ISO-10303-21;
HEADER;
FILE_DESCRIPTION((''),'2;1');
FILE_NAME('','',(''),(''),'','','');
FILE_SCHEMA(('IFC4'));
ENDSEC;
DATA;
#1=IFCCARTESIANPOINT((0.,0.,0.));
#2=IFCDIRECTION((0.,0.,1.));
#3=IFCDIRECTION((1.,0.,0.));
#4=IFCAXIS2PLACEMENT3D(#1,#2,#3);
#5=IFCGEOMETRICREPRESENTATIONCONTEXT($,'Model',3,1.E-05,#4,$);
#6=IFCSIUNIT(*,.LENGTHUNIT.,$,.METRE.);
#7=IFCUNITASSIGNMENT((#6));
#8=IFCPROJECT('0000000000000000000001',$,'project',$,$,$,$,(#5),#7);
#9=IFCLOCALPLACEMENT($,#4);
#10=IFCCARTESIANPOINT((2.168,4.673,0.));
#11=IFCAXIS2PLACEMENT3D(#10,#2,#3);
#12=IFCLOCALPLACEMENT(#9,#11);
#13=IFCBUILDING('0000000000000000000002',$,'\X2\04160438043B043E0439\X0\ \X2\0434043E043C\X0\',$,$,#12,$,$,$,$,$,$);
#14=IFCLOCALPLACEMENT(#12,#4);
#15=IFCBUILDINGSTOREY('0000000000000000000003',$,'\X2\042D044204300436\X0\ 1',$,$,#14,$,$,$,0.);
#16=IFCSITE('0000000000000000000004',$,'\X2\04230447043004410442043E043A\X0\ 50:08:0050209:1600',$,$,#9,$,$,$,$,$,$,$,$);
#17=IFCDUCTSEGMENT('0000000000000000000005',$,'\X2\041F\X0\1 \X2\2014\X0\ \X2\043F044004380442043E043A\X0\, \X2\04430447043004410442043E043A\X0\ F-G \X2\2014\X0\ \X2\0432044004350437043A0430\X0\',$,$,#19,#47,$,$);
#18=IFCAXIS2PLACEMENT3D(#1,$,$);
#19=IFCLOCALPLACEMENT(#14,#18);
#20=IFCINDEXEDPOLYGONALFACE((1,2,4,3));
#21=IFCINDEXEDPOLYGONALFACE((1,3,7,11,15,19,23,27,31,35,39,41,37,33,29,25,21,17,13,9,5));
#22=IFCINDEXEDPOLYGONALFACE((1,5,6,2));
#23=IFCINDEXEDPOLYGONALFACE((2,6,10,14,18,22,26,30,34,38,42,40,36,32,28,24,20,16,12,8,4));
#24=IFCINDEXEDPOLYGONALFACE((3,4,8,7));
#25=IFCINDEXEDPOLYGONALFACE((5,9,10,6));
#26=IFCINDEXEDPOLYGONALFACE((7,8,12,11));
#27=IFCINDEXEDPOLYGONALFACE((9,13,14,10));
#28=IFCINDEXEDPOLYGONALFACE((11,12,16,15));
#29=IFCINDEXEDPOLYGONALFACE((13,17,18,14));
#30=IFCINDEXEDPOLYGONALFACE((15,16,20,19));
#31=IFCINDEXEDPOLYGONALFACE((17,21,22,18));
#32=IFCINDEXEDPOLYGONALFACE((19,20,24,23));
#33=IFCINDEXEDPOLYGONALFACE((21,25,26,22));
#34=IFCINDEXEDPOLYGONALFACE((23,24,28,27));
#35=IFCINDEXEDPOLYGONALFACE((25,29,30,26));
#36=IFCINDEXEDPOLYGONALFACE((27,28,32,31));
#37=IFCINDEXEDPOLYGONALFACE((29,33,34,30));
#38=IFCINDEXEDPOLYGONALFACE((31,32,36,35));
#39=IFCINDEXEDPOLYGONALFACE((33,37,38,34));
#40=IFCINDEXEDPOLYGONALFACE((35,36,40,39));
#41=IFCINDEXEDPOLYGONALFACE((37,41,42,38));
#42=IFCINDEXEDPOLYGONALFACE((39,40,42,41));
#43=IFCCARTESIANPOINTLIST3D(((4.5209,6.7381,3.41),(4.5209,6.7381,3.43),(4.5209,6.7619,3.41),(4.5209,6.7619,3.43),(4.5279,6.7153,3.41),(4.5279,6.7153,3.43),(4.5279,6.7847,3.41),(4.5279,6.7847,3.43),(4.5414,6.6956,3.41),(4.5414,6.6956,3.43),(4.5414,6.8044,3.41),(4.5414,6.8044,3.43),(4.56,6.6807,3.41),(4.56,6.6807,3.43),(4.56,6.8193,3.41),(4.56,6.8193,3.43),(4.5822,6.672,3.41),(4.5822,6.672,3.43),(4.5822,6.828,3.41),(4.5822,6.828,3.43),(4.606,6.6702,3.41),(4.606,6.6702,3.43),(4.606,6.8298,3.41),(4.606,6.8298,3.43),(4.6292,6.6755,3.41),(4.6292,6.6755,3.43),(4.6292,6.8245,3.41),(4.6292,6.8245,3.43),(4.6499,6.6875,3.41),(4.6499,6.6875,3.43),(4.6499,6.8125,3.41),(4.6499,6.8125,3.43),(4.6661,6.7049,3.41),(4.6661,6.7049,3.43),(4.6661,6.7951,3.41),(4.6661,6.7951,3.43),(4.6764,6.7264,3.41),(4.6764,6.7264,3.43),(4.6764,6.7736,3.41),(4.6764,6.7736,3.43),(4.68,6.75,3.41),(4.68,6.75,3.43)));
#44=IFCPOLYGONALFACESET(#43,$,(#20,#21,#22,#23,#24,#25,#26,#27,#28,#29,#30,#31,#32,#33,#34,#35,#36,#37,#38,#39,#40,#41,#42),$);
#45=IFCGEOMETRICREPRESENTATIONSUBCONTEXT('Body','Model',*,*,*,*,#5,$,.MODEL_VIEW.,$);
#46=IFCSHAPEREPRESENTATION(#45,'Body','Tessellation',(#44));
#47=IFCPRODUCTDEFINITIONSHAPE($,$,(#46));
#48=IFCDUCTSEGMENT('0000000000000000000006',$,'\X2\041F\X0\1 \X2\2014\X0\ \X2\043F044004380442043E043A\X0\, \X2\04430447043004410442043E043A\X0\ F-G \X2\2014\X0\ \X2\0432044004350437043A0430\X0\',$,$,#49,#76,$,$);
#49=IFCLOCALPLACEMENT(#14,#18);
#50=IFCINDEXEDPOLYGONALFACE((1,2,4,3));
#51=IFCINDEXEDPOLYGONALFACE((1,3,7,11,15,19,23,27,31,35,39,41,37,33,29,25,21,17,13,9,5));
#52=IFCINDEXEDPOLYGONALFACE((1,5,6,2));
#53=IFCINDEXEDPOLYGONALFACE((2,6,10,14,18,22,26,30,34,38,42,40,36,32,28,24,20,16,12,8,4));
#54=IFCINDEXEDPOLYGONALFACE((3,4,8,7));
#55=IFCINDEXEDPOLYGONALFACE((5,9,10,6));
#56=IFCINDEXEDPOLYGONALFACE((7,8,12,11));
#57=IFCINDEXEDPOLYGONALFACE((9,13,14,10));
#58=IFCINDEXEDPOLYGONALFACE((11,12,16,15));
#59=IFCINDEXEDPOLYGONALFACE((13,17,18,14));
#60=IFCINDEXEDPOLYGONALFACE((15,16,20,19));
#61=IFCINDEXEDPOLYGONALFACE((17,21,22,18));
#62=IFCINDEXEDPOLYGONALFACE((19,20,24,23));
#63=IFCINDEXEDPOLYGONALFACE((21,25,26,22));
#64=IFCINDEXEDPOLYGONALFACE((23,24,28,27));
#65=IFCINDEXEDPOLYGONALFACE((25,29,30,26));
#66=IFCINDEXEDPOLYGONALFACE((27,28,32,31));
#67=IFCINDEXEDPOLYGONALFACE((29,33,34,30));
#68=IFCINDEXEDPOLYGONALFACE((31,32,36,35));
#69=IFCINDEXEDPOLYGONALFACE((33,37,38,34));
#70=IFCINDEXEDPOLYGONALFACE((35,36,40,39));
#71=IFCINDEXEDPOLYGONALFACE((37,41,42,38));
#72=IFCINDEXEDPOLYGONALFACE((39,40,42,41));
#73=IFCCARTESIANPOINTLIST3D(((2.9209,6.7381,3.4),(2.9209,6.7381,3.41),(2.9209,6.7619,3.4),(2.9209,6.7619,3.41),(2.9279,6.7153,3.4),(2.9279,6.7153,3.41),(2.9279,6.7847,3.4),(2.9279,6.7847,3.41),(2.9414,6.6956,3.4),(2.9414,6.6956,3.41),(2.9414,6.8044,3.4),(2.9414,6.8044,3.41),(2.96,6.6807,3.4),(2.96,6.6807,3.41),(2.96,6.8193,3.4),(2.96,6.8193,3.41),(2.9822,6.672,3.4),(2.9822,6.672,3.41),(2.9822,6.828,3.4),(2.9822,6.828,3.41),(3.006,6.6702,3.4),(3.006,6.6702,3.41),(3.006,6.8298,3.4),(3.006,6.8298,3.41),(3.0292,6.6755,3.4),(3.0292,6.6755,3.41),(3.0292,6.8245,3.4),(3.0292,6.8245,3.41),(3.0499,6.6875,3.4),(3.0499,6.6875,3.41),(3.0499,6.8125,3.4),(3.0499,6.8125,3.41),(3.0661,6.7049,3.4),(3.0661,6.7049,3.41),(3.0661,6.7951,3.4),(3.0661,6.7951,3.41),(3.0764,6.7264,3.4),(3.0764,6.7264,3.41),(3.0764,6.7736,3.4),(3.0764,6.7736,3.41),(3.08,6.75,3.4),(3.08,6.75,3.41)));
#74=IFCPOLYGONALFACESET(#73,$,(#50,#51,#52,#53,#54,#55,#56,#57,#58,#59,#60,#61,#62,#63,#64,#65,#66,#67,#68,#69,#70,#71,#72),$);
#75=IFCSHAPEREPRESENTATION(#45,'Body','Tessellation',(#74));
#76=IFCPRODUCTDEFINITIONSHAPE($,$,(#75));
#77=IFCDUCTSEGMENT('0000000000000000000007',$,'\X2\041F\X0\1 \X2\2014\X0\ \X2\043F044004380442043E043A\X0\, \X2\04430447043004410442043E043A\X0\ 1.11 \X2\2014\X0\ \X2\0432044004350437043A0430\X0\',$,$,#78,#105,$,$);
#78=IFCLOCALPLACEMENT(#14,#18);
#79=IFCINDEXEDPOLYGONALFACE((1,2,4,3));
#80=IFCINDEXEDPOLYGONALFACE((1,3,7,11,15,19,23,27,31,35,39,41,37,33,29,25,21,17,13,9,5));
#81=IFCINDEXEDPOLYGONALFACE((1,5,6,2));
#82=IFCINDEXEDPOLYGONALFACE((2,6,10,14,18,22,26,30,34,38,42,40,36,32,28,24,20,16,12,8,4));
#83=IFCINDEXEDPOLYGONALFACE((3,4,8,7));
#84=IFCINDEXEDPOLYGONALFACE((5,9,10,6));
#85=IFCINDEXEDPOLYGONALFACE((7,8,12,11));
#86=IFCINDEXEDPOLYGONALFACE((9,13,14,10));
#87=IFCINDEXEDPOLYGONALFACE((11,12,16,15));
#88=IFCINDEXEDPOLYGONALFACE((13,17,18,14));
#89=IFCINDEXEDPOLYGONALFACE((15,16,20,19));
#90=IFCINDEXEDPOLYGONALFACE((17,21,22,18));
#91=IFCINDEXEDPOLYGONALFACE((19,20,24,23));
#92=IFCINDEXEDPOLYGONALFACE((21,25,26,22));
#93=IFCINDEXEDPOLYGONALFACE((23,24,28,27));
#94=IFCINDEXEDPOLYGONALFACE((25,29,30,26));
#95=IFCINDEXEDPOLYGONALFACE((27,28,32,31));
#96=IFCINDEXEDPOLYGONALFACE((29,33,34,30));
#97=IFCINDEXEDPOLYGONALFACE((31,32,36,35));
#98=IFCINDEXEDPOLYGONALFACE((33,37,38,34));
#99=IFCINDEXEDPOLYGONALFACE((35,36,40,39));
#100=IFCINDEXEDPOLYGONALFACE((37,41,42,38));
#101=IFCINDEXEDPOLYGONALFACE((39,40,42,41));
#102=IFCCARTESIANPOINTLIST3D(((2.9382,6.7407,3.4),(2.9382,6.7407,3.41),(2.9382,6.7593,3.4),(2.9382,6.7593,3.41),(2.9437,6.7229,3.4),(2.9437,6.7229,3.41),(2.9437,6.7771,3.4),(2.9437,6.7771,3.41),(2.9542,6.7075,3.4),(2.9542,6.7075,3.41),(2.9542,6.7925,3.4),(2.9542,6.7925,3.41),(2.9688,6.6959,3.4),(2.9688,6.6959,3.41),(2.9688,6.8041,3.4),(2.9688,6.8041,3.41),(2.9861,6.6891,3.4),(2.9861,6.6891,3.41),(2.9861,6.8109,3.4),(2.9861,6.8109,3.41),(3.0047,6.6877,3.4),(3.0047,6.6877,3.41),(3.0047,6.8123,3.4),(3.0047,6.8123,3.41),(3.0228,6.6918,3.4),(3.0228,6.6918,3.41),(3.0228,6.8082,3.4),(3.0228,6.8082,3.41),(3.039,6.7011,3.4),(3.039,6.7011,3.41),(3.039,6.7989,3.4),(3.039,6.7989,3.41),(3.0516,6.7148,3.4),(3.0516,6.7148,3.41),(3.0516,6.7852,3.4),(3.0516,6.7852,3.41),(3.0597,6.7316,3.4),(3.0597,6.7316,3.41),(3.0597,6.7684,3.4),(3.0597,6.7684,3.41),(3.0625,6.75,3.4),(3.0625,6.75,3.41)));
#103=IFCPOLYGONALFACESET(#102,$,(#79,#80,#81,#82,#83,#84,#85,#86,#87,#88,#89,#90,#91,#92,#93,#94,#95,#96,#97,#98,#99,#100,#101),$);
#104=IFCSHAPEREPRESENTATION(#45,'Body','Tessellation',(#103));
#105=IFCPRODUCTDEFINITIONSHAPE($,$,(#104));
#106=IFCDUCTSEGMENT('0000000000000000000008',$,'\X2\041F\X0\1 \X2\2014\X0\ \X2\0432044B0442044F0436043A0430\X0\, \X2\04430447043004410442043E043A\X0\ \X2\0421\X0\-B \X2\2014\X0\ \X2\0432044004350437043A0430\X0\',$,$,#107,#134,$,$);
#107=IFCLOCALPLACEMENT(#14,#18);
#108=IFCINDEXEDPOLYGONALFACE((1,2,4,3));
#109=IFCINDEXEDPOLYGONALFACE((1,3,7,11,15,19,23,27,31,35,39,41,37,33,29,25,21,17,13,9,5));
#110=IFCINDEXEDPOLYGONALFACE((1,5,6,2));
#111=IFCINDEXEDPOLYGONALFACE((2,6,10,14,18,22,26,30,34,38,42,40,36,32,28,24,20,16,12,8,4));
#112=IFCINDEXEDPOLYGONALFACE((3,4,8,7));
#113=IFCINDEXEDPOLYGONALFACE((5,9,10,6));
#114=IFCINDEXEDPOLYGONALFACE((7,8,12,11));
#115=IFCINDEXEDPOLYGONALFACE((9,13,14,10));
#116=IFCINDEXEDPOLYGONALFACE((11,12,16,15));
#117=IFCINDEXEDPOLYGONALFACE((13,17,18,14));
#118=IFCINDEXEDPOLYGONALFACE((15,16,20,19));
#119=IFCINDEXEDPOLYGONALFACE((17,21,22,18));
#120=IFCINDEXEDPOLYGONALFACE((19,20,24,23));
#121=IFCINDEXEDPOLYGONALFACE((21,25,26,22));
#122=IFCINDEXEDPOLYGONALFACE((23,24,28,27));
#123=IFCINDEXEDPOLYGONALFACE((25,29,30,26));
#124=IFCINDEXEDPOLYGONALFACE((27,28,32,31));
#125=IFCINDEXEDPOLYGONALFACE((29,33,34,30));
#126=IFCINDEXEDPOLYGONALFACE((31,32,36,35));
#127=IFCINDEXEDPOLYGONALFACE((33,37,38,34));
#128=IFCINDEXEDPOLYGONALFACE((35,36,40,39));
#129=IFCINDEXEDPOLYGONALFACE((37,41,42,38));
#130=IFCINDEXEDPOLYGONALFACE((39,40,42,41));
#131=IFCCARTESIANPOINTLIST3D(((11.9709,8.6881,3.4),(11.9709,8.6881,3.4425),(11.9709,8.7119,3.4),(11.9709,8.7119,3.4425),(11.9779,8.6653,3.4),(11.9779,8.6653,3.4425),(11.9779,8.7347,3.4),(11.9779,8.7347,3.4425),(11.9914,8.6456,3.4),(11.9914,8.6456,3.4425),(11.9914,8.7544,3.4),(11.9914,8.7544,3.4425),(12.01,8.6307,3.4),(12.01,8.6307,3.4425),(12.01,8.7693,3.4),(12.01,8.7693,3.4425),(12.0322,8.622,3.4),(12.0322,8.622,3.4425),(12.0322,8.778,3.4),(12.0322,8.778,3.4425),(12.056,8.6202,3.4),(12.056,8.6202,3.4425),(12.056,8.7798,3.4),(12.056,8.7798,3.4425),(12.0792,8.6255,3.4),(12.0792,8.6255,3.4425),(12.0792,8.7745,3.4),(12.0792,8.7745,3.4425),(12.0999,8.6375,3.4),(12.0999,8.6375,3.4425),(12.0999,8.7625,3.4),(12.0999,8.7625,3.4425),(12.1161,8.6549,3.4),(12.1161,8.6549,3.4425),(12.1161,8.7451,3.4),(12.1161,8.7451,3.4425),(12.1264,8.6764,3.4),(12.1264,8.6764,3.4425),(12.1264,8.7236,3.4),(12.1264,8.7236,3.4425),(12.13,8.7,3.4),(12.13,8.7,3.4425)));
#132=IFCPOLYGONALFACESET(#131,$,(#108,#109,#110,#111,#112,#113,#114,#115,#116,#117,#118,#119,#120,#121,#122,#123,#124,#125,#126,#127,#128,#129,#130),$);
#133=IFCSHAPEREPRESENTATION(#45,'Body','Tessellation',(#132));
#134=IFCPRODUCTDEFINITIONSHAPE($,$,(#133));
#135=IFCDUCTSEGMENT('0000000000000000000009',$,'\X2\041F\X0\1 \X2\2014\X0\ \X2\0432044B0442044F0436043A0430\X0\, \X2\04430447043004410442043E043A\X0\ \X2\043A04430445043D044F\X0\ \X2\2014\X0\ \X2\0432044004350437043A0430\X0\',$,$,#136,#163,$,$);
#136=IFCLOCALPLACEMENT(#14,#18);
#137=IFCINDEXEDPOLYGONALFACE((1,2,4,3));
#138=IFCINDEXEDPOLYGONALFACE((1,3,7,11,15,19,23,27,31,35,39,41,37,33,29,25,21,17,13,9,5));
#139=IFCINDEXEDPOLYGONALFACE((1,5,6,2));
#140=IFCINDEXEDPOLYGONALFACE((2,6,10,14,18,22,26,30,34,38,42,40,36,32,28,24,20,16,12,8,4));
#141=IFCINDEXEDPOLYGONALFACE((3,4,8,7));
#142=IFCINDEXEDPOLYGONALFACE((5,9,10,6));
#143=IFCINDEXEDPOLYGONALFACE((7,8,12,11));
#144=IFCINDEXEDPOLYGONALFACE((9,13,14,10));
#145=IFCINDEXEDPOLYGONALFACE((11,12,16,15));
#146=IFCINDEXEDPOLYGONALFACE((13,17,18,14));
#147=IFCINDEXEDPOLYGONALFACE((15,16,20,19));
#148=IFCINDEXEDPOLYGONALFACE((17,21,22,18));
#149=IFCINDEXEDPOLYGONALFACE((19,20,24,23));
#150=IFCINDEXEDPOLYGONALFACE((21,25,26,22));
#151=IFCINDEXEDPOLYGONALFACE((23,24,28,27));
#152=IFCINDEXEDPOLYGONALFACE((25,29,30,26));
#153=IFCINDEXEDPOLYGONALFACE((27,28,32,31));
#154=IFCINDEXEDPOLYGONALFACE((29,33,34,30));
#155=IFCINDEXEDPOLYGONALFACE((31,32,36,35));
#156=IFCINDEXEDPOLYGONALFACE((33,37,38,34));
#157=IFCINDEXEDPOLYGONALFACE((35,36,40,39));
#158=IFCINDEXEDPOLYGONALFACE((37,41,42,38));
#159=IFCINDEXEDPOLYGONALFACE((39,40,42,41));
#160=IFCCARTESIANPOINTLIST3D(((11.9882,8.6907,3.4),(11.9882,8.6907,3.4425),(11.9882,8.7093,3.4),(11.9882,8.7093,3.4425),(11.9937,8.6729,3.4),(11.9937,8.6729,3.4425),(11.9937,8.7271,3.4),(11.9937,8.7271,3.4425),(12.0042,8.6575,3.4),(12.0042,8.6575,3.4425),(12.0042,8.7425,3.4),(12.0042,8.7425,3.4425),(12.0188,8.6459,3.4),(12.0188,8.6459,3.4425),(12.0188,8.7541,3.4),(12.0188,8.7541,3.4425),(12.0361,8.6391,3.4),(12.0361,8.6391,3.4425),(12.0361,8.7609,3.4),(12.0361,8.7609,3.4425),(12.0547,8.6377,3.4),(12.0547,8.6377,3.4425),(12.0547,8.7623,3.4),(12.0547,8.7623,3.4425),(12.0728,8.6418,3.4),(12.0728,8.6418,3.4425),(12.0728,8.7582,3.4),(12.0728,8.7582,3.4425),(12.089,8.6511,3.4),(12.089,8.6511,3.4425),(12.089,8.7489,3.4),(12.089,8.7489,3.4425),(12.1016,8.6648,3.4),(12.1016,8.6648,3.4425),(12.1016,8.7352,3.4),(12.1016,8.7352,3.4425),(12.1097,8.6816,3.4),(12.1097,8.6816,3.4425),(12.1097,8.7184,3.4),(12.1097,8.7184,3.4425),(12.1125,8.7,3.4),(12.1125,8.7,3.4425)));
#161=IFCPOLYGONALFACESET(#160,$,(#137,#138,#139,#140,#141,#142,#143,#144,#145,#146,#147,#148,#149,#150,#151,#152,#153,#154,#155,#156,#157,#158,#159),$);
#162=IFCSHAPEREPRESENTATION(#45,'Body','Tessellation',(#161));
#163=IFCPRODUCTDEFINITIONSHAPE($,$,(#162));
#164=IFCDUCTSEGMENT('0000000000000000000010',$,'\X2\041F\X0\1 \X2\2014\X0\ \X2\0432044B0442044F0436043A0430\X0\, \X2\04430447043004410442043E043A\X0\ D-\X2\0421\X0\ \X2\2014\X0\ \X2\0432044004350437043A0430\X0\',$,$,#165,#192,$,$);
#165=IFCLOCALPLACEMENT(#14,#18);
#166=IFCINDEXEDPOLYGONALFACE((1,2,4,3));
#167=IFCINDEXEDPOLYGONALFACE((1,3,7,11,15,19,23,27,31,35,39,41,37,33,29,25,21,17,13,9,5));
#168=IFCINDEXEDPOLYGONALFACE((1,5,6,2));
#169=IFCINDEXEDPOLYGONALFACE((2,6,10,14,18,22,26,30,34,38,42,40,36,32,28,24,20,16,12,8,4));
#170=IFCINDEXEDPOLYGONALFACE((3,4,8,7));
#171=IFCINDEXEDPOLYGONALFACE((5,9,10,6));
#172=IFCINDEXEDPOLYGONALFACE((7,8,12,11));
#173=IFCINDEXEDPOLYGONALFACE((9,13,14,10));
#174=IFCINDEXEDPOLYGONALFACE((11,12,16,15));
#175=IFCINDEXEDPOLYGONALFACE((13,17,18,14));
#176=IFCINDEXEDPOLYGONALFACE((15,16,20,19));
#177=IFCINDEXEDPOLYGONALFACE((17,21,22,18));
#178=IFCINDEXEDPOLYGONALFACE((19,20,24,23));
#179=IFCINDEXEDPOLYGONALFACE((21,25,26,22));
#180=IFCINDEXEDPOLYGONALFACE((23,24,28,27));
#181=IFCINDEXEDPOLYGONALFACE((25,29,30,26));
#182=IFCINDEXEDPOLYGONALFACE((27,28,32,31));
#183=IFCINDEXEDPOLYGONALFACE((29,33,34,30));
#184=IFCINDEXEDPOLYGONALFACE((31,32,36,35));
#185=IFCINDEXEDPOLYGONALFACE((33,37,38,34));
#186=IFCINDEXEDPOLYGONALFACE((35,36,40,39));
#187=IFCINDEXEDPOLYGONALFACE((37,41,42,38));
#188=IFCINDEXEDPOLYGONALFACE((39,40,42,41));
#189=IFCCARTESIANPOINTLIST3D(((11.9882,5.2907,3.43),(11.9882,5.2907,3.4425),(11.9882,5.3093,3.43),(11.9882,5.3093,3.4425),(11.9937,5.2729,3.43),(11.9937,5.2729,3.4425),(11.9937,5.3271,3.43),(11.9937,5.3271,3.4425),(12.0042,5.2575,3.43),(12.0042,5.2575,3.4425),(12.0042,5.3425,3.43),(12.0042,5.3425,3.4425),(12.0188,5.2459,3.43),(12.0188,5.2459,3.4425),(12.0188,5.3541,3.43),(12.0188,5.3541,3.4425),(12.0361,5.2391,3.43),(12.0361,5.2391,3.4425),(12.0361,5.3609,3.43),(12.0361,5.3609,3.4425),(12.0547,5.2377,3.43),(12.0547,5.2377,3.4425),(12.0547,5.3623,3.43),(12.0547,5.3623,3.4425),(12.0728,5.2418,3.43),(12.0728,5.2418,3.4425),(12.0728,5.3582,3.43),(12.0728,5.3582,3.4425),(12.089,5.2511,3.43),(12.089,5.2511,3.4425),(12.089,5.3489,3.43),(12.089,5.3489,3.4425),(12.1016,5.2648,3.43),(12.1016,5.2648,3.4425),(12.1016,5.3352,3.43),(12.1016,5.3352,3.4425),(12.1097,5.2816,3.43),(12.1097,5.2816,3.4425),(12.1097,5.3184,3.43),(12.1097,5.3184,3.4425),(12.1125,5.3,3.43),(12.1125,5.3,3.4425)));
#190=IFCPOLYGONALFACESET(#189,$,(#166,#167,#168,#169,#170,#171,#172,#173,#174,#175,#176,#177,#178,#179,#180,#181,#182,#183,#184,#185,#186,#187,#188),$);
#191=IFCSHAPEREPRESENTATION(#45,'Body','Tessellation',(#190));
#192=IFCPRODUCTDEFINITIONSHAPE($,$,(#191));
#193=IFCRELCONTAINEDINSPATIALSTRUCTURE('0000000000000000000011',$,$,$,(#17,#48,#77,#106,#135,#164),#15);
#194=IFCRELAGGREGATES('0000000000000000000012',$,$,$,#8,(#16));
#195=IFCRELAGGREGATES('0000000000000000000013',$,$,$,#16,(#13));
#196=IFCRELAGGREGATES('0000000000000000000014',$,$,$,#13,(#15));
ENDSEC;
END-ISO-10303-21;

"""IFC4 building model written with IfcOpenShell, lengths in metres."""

from ifc_helpers import new_model, si_unit, frame, origin_with_axes, origin_2d, place, context, subcontext, project, spatial, circle, extrude, element, save


model = new_model("IFC4")

# Units and contexts
model_context = context("Model", 3, precision=1e-05, world=origin_with_axes())
body_context = subcontext(model_context, "Body", "Model", "MODEL_VIEW")
ifc_project = project(units=[si_unit("LENGTHUNIT", "METRE")], contexts=[model_context])

# Site, building, storey
site_placement = place(None, origin_with_axes())
site = spatial("IfcSite", under=ifc_project, at=site_placement, Name="Участок 50:08:0050209:1600")
building_placement = place(site_placement, frame((2.168, 4.673, 0.0), z_axis=(0.0, 0.0, 1.0), x_axis=(1.0, 0.0, 0.0)))
building = spatial("IfcBuilding", under=site, at=building_placement, Name="Жилой дом")
storey_placement = place(building_placement, origin_with_axes())
storey = spatial("IfcBuildingStorey", under=building, at=storey_placement, Name="Этаж 1", Elevation=0.0)

# Duct segments
duct_segment_1_placement = place(storey_placement, origin_with_axes())
element("IfcDuctSegment", 1, at=duct_segment_1_placement, inside=storey, Name="П1 — приток, участок F-G — врезка", context=body_context, shape_type="SweptSolid", body=[
    extrude(circle(Radius=0.08, at=origin_2d()), frame((4.6, 6.75, 3.41), z_axis=(0.0, 0.0, 1.0), x_axis=(1.0, 0.0, 0.0)), (0.0, 0.0, 1.0), 0.02),
])
duct_segment_2_placement = place(storey_placement, origin_with_axes())
element("IfcDuctSegment", 2, at=duct_segment_2_placement, inside=storey, Name="П1 — приток, участок F-G — врезка", context=body_context, shape_type="SweptSolid", body=[
    extrude(circle(Radius=0.08, at=origin_2d()), frame((3.0, 6.75, 3.41), z_axis=(0.0, 0.0, -1.0), x_axis=(1.0, 0.0, 0.0)), (0.0, 0.0, 1.0), 0.01),
])
for number, where, z_axis, x_axis, name in (
    (3, (0.0, 0.0, 0.0), (0.0, 0.0, 1.0), (1.0, 0.0, 0.0), "П1 — приток, участок 1.11 — врезка"),
):
    element("IfcDuctSegment", number, at=place(storey_placement, frame(where, z_axis=z_axis, x_axis=x_axis)), inside=storey, Name=name, context=body_context, shape_type="SweptSolid", body=[
        extrude(circle(Radius=0.0625, at=origin_2d()), frame((3.0, 6.75, 3.4), z_axis=(0.0, 0.0, 1.0), x_axis=(1.0, 0.0, 0.0)), (0.0, 0.0, 1.0), 0.01),
    ])
duct_segment_3_placement = place(storey_placement, origin_with_axes())
element("IfcDuctSegment", 4, at=duct_segment_3_placement, inside=storey, Name="П1 — вытяжка, участок С-B — врезка", context=body_context, shape_type="SweptSolid", body=[
    extrude(circle(Radius=0.08, at=origin_2d()), frame((12.05, 8.7, 3.4), z_axis=(0.0, 0.0, 1.0), x_axis=(1.0, 0.0, 0.0)), (0.0, 0.0, 1.0), 0.0425),
])
duct_segment_4_placement = place(storey_placement, origin_with_axes())
element("IfcDuctSegment", 5, at=duct_segment_4_placement, inside=storey, Name="П1 — вытяжка, участок кухня — врезка", context=body_context, shape_type="SweptSolid", body=[
    extrude(circle(Radius=0.0625, at=origin_2d()), frame((12.05, 8.7, 3.4), z_axis=(0.0, 0.0, 1.0), x_axis=(1.0, 0.0, 0.0)), (0.0, 0.0, 1.0), 0.0425),
])
duct_segment_5_placement = place(storey_placement, origin_with_axes())
element("IfcDuctSegment", 6, at=duct_segment_5_placement, inside=storey, Name="П1 — вытяжка, участок D-С — врезка", context=body_context, shape_type="SweptSolid", body=[
    extrude(circle(Radius=0.0625, at=origin_2d()), frame((12.05, 5.3, 3.4425), z_axis=(0.0, 0.0, -1.0), x_axis=(1.0, 0.0, 0.0)), (0.0, 0.0, 1.0), 0.0125),
])

save(model, "model.ifc")
